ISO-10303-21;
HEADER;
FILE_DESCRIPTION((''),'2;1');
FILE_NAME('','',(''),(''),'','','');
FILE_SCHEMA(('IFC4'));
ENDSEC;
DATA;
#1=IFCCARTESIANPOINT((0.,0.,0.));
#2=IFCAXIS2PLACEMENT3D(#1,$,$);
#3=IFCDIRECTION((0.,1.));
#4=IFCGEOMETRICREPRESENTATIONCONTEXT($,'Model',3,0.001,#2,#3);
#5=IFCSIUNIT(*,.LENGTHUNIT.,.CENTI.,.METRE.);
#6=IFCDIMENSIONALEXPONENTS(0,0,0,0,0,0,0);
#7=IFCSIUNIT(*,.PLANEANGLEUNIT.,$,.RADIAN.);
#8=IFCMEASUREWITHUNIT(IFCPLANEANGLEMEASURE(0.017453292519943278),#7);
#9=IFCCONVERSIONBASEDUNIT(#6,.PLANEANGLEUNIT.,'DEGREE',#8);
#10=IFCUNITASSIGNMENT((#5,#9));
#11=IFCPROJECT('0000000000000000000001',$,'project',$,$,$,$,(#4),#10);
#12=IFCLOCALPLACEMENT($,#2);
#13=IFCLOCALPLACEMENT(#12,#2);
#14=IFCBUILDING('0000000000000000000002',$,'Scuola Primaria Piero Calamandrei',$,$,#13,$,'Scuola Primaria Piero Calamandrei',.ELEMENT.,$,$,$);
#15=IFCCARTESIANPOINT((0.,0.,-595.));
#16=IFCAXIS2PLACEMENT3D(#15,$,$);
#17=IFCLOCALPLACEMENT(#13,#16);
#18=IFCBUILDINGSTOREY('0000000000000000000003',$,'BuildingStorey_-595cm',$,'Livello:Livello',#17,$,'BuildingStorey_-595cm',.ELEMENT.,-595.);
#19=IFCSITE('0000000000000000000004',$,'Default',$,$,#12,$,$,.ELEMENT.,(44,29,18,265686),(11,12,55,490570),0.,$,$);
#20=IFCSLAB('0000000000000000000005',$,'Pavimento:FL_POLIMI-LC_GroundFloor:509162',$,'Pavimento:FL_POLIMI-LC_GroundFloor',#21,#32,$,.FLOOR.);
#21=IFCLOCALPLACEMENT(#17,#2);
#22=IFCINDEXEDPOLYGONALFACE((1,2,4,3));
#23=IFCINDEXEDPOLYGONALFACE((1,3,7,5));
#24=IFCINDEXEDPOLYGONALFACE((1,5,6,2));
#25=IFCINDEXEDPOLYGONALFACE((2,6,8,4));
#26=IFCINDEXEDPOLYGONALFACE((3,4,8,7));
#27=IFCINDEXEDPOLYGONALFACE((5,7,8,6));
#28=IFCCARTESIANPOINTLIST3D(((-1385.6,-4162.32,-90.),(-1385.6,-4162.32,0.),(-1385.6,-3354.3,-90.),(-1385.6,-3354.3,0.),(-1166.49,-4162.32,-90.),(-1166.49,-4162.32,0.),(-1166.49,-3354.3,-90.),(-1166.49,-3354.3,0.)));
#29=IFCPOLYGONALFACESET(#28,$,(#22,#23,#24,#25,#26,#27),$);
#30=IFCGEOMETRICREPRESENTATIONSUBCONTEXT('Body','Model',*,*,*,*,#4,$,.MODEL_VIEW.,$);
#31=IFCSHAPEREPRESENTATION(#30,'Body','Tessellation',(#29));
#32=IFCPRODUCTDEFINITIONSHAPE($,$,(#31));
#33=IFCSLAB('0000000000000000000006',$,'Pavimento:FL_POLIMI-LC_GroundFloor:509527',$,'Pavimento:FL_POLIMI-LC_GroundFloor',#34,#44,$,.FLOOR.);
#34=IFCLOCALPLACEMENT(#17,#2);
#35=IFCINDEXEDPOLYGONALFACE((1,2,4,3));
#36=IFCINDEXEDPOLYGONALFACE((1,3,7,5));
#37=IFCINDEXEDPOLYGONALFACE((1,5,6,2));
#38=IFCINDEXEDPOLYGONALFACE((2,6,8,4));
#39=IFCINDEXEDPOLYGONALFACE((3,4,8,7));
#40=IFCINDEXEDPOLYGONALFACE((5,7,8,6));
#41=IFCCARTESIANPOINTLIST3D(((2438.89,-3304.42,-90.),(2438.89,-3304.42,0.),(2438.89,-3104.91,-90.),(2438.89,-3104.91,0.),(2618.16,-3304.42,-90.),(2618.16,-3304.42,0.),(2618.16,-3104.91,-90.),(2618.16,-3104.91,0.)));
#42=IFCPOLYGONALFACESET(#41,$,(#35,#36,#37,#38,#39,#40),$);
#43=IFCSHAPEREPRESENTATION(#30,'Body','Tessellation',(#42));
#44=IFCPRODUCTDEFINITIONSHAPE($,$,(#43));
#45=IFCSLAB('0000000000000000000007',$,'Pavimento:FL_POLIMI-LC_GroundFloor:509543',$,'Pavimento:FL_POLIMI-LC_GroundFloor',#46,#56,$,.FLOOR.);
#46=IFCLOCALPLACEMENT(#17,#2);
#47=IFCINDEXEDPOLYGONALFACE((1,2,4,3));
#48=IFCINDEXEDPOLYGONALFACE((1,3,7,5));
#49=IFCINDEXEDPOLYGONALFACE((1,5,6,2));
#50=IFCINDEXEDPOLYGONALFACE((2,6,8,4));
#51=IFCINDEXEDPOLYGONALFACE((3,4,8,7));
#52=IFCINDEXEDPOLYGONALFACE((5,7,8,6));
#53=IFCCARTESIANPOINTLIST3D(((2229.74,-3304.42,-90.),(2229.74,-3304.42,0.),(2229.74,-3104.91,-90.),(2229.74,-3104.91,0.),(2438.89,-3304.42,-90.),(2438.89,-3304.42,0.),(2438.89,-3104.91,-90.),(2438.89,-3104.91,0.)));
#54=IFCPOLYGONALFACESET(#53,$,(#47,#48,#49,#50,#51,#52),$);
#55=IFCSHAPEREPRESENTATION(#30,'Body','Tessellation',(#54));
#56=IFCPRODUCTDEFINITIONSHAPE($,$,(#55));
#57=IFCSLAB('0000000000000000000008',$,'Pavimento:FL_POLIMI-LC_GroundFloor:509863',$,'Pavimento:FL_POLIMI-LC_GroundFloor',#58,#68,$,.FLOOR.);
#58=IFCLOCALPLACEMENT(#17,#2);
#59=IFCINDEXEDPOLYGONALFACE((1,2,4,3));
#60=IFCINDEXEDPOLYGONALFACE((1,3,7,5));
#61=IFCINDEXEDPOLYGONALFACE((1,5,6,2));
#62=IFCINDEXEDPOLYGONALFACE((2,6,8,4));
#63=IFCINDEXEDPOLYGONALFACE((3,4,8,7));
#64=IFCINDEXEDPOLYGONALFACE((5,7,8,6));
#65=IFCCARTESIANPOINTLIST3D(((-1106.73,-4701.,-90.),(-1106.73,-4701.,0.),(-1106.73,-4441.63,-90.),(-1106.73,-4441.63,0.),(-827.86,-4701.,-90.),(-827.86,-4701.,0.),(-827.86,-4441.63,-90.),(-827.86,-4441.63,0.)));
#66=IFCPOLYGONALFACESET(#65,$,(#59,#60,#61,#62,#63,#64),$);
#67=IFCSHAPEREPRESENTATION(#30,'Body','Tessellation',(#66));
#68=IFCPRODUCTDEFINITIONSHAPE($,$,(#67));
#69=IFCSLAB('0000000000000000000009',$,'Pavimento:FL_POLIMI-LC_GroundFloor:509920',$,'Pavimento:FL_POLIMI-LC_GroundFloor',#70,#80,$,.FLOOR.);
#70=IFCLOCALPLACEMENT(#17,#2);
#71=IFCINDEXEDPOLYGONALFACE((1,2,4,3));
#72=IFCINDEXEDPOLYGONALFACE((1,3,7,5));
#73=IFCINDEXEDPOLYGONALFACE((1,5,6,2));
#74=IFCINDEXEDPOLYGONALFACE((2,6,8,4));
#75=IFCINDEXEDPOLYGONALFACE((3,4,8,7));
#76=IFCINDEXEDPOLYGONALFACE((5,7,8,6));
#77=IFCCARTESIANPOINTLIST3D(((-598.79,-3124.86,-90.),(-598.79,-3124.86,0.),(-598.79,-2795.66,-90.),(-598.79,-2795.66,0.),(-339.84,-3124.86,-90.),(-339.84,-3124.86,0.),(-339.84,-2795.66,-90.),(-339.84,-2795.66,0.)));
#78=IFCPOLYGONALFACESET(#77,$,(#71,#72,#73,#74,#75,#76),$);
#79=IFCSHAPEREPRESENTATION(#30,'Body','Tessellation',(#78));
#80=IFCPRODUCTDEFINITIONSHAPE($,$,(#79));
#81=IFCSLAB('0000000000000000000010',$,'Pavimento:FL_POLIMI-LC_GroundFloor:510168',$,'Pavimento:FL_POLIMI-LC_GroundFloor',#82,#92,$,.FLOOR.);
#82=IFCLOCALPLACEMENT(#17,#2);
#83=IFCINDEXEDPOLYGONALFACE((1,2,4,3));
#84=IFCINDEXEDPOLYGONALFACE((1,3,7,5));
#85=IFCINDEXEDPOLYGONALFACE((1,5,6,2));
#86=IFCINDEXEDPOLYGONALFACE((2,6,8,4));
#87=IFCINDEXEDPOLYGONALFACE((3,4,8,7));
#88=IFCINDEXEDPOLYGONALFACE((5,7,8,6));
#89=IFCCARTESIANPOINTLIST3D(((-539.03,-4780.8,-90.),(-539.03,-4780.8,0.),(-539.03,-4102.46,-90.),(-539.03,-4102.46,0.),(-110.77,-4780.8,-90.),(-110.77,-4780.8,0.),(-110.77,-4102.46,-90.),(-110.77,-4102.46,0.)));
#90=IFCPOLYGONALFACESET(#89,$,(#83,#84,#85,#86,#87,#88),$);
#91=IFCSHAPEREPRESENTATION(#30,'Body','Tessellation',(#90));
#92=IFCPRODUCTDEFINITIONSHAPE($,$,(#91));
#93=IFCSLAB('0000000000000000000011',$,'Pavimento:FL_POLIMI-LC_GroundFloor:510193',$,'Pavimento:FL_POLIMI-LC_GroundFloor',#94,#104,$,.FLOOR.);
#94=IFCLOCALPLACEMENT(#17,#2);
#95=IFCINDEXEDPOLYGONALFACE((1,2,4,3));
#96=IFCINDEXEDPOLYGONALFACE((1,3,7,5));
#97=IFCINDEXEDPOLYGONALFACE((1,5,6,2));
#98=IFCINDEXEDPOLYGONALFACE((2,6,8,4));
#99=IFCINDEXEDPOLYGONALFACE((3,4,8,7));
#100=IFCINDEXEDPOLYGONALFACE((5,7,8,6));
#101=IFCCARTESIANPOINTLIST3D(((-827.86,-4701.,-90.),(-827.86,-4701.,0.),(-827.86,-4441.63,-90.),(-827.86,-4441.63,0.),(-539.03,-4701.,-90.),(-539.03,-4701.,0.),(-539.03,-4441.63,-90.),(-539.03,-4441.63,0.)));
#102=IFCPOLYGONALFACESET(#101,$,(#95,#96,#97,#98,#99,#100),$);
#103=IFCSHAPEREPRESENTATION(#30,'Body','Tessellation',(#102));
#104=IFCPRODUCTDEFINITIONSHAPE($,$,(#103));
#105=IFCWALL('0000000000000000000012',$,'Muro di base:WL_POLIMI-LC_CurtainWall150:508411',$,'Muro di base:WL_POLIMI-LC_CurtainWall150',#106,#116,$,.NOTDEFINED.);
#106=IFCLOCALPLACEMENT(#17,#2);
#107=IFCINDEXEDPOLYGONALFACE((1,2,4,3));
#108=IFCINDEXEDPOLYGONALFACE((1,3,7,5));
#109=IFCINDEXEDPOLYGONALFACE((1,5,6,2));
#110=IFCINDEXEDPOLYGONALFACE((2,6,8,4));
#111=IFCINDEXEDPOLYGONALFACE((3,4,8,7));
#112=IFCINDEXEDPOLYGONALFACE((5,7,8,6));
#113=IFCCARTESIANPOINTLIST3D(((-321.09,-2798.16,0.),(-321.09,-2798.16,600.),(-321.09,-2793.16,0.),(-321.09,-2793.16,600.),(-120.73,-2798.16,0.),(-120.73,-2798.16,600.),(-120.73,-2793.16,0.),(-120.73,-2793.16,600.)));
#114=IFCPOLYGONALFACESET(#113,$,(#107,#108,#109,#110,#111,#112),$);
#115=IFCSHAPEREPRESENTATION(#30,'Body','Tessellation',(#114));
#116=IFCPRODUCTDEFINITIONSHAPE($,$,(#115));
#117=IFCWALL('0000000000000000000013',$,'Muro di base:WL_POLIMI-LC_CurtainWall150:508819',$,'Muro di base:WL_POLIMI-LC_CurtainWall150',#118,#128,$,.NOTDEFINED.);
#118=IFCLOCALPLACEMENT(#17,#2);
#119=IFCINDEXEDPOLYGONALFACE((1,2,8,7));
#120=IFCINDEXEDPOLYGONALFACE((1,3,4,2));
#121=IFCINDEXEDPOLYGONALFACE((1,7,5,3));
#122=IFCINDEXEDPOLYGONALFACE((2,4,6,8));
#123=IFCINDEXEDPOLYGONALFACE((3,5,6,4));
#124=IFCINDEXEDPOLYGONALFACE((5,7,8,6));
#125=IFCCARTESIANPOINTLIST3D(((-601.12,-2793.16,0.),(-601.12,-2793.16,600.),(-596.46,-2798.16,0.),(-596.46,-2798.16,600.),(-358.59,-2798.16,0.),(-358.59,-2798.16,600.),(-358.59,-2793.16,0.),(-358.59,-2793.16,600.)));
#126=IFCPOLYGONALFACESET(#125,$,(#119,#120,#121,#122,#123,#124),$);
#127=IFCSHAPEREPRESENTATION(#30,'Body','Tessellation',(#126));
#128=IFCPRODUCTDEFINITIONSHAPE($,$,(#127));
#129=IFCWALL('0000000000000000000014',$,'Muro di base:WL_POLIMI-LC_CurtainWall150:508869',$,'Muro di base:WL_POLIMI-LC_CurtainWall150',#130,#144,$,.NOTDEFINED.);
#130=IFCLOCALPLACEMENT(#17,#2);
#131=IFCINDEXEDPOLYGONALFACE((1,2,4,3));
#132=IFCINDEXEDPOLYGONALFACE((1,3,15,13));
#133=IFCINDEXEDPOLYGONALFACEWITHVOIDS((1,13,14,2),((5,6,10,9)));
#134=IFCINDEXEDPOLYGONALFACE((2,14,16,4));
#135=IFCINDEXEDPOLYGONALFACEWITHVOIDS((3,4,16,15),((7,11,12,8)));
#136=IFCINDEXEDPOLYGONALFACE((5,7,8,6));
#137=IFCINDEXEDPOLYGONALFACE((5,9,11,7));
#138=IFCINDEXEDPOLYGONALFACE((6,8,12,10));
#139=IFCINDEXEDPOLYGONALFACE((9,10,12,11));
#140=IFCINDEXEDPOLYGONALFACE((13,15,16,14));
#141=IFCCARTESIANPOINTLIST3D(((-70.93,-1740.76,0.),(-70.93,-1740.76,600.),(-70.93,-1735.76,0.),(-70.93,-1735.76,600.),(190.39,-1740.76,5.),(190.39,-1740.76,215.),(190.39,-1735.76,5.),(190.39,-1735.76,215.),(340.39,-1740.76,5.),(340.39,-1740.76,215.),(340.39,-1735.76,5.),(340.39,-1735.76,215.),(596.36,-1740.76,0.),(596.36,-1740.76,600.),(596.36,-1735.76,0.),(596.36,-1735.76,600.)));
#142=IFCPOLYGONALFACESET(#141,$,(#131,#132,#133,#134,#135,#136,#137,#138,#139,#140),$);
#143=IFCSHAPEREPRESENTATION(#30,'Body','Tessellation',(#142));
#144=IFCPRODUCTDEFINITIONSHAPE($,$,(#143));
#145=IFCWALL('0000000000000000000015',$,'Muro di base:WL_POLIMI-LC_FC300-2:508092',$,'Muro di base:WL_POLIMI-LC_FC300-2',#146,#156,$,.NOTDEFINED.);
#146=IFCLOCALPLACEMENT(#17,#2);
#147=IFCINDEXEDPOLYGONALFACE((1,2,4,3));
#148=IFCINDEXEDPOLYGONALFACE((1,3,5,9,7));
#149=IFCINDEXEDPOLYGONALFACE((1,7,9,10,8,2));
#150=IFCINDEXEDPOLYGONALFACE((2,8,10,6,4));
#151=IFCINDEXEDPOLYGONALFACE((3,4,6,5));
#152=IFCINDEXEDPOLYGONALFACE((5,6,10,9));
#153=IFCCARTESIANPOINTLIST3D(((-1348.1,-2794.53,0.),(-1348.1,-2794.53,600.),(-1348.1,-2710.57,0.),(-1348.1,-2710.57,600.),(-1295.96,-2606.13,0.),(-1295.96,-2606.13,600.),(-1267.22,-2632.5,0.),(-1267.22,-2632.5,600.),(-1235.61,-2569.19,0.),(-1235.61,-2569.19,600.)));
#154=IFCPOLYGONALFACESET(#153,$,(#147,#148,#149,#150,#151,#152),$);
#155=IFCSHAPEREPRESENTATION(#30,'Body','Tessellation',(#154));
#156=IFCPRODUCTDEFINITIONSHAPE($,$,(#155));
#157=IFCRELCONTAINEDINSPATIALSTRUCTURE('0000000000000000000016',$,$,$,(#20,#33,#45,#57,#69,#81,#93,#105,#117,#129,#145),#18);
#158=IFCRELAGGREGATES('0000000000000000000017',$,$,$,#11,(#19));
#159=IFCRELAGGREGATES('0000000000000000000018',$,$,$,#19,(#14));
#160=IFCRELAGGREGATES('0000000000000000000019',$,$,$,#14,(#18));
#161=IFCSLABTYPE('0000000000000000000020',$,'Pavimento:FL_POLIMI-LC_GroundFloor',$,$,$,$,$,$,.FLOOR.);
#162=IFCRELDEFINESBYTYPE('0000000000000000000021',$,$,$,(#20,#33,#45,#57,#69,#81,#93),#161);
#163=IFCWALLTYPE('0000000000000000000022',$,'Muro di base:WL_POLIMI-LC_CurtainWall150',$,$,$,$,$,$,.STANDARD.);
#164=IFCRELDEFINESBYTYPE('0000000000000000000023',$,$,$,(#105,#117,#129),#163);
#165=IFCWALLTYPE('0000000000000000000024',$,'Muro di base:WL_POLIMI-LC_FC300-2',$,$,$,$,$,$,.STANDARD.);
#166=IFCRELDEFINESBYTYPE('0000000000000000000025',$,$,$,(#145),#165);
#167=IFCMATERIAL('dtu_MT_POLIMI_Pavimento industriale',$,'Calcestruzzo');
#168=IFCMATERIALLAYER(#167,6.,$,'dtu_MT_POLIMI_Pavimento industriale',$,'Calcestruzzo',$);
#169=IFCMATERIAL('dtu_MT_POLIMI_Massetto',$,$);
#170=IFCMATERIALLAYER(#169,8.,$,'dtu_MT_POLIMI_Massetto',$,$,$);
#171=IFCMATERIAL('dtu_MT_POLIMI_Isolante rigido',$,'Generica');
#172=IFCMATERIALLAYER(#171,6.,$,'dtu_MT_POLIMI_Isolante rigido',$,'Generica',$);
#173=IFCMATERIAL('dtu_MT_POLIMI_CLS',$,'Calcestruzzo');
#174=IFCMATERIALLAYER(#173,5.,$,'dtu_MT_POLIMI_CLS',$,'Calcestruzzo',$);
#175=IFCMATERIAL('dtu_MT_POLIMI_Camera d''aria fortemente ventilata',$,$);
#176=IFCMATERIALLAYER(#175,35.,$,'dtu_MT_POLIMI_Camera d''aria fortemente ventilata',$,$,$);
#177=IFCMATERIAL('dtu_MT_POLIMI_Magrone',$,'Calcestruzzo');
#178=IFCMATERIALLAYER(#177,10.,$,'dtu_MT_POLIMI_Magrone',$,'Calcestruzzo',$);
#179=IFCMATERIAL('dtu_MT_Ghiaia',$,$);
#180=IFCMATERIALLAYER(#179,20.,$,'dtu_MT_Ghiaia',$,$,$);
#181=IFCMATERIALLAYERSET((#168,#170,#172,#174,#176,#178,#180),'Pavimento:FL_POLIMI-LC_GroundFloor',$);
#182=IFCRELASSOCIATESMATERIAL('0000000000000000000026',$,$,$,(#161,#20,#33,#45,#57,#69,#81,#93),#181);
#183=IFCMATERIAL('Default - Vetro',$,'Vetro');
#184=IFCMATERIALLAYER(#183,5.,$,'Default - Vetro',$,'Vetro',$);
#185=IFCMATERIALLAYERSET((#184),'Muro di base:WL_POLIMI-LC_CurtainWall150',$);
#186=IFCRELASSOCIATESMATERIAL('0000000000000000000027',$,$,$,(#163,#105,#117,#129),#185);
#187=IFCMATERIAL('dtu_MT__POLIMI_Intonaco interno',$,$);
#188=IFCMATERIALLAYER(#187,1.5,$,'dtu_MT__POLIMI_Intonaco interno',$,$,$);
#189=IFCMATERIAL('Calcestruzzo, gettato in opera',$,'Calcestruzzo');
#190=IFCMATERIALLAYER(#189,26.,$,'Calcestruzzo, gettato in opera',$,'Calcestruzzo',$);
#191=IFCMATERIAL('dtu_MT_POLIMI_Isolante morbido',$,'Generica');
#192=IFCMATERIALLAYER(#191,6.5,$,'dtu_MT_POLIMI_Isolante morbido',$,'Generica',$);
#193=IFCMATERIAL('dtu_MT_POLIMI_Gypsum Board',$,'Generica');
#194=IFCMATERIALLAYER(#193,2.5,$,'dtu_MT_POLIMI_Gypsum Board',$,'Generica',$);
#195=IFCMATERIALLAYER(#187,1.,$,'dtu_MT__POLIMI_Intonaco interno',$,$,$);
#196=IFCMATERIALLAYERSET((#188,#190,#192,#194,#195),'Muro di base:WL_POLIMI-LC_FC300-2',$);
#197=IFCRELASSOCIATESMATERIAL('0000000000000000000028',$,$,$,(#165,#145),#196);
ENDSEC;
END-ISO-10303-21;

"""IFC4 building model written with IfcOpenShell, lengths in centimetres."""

from ifc_helpers import new_model, entity, si_unit, converted_unit, direction, frame, frame_2d, origin, place, context, subcontext, project, spatial, polyline, rectangle, outline, extrude, material, layer, layer_set, layer_usage, type_object, element, save


model = new_model("IFC4")

# Units and contexts
model_context = context("Model", 3, precision=0.001, world=origin(), true_north=direction((0.0, 1.0)))
body_context = subcontext(model_context, "Body", "Model", "MODEL_VIEW")
ifc_project = project(units=[si_unit("LENGTHUNIT", "METRE", prefix="CENTI"), converted_unit("PLANEANGLEUNIT", "DEGREE", entity("IfcPlaneAngleMeasure", 0.017453292519943278), si_unit("PLANEANGLEUNIT", "RADIAN"), dimensions=[0, 0, 0, 0, 0, 0, 0])], contexts=[model_context])

# Site, building, storey
site_placement = place(None, origin())
site = spatial("IfcSite", under=ifc_project, at=site_placement, Name="Default", CompositionType="ELEMENT", RefLatitude=(44, 29, 18, 265686), RefLongitude=(11, 12, 55, 490570), RefElevation=0.0)
building_placement = place(site_placement, origin())
building = spatial("IfcBuilding", under=site, at=building_placement, Name="Scuola Primaria Piero Calamandrei", LongName="Scuola Primaria Piero Calamandrei", CompositionType="ELEMENT")
storey_placement = place(building_placement, frame((0.0, 0.0, -595.0)))
storey = spatial("IfcBuildingStorey", under=building, at=storey_placement, Name="BuildingStorey_-595cm", ObjectType="Livello:Livello", LongName="BuildingStorey_-595cm", CompositionType="ELEMENT", Elevation=-595.0)

# Slabs
ifc_material_1 = material(Name="dtu_MT_POLIMI_Pavimento industriale", Category="Calcestruzzo")
ifc_layer_1 = layer(ifc_material_1, 6.0, Name="dtu_MT_POLIMI_Pavimento industriale", Category="Calcestruzzo")
ifc_material_2 = material(Name="dtu_MT_POLIMI_Massetto")
ifc_layer_2 = layer(ifc_material_2, 8.0, Name="dtu_MT_POLIMI_Massetto")
ifc_material_3 = material(Name="dtu_MT_POLIMI_Isolante rigido", Category="Generica")
ifc_layer_3 = layer(ifc_material_3, 6.0, Name="dtu_MT_POLIMI_Isolante rigido", Category="Generica")
ifc_material_4 = material(Name="dtu_MT_POLIMI_CLS", Category="Calcestruzzo")
ifc_layer_4 = layer(ifc_material_4, 5.0, Name="dtu_MT_POLIMI_CLS", Category="Calcestruzzo")
ifc_material_5 = material(Name="dtu_MT_POLIMI_Camera d'aria fortemente ventilata")
ifc_layer_5 = layer(ifc_material_5, 35.0, Name="dtu_MT_POLIMI_Camera d'aria fortemente ventilata")
ifc_material_6 = material(Name="dtu_MT_POLIMI_Magrone", Category="Calcestruzzo")
ifc_layer_6 = layer(ifc_material_6, 10.0, Name="dtu_MT_POLIMI_Magrone", Category="Calcestruzzo")
ifc_material_7 = material(Name="dtu_MT_Ghiaia")
ifc_layer_7 = layer(ifc_material_7, 20.0, Name="dtu_MT_Ghiaia")
ifc_layer_set_1 = layer_set([ifc_layer_1, ifc_layer_2, ifc_layer_3, ifc_layer_4, ifc_layer_5, ifc_layer_6, ifc_layer_7], Name="Pavimento:FL_POLIMI-LC_GroundFloor")
slab_type = type_object("IfcSlabType", Name="Pavimento:FL_POLIMI-LC_GroundFloor", PredefinedType="FLOOR", material=ifc_layer_set_1)
ifc_layer_usage_1 = layer_usage(ifc_layer_set_1, "AXIS3", "POSITIVE", 0.0)
slab_1_placement = place(storey_placement, origin())
element("IfcSlab", 1, at=slab_1_placement, inside=storey, type_object=slab_type, material=ifc_layer_usage_1, Name="Pavimento:FL_POLIMI-LC_GroundFloor:509162", ObjectType="Pavimento:FL_POLIMI-LC_GroundFloor", PredefinedType="FLOOR", context=body_context, shape_type="SweptSolid", body=[
    extrude(rectangle(XDim=808.02, YDim=219.11, at=frame_2d((0.0, 0.0), x_axis=(1.0, 0.0))), frame((-1276.05, -3758.31, 0.0), z_axis=(0.0, 0.0, -1.0), x_axis=(0.0, 1.0, 0.0)), (0.0, 0.0, 1.0), 90.0),
])
ifc_layer_usage_2 = layer_usage(ifc_layer_set_1, "AXIS3", "POSITIVE", 0.0)
slab_2_placement = place(storey_placement, origin())
element("IfcSlab", 2, at=slab_2_placement, inside=storey, type_object=slab_type, material=ifc_layer_usage_2, Name="Pavimento:FL_POLIMI-LC_GroundFloor:509527", ObjectType="Pavimento:FL_POLIMI-LC_GroundFloor", PredefinedType="FLOOR", context=body_context, shape_type="SweptSolid", body=[
    extrude(rectangle(XDim=199.51, YDim=179.27, at=frame_2d((0.0, 0.0), x_axis=(1.0, 0.0))), frame((2528.53, -3204.66, 0.0), z_axis=(0.0, 0.0, -1.0), x_axis=(0.0, 1.0, 0.0)), (0.0, 0.0, 1.0), 90.0),
])
ifc_layer_usage_3 = layer_usage(ifc_layer_set_1, "AXIS3", "POSITIVE", 0.0)
slab_3_placement = place(storey_placement, origin())
element("IfcSlab", 3, at=slab_3_placement, inside=storey, type_object=slab_type, material=ifc_layer_usage_3, Name="Pavimento:FL_POLIMI-LC_GroundFloor:509543", ObjectType="Pavimento:FL_POLIMI-LC_GroundFloor", PredefinedType="FLOOR", context=body_context, shape_type="SweptSolid", body=[
    extrude(rectangle(XDim=199.51, YDim=209.15, at=frame_2d((0.0, 0.0), x_axis=(1.0, 0.0))), frame((2334.32, -3204.66, 0.0), z_axis=(0.0, 0.0, -1.0), x_axis=(0.0, 1.0, 0.0)), (0.0, 0.0, 1.0), 90.0),
])
ifc_layer_usage_4 = layer_usage(ifc_layer_set_1, "AXIS3", "POSITIVE", 0.0)
slab_4_placement = place(storey_placement, origin())
element("IfcSlab", 4, at=slab_4_placement, inside=storey, type_object=slab_type, material=ifc_layer_usage_4, Name="Pavimento:FL_POLIMI-LC_GroundFloor:509863", ObjectType="Pavimento:FL_POLIMI-LC_GroundFloor", PredefinedType="FLOOR", context=body_context, shape_type="SweptSolid", body=[
    extrude(rectangle(XDim=259.36, YDim=278.87, at=frame_2d((0.0, 0.0), x_axis=(1.0, 0.0))), frame((-967.3, -4571.31, 0.0), z_axis=(0.0, 0.0, -1.0), x_axis=(0.0, 1.0, 0.0)), (0.0, 0.0, 1.0), 90.0),
])
ifc_layer_usage_5 = layer_usage(ifc_layer_set_1, "AXIS3", "POSITIVE", 0.0)
slab_5_placement = place(storey_placement, origin())
element("IfcSlab", 5, at=slab_5_placement, inside=storey, type_object=slab_type, material=ifc_layer_usage_5, Name="Pavimento:FL_POLIMI-LC_GroundFloor:509920", ObjectType="Pavimento:FL_POLIMI-LC_GroundFloor", PredefinedType="FLOOR", context=body_context, shape_type="SweptSolid", body=[
    extrude(rectangle(XDim=329.19, YDim=258.95, at=frame_2d((0.0, 0.0), x_axis=(1.0, 0.0))), frame((-469.32, -2960.26, 0.0), z_axis=(0.0, 0.0, -1.0), x_axis=(0.0, 1.0, 0.0)), (0.0, 0.0, 1.0), 90.0),
])
ifc_layer_usage_6 = layer_usage(ifc_layer_set_1, "AXIS3", "POSITIVE", 0.0)
slab_6_placement = place(storey_placement, origin())
element("IfcSlab", 6, at=slab_6_placement, inside=storey, type_object=slab_type, material=ifc_layer_usage_6, Name="Pavimento:FL_POLIMI-LC_GroundFloor:510168", ObjectType="Pavimento:FL_POLIMI-LC_GroundFloor", PredefinedType="FLOOR", context=body_context, shape_type="SweptSolid", body=[
    extrude(rectangle(XDim=428.26, YDim=678.34, at=frame_2d((0.0, 0.0), x_axis=(1.0, 0.0))), frame((-324.9, -4441.63, 0.0), z_axis=(0.0, 0.0, -1.0), x_axis=(1.0, 0.0, 0.0)), (0.0, 0.0, 1.0), 90.0),
])
ifc_layer_usage_7 = layer_usage(ifc_layer_set_1, "AXIS3", "POSITIVE", 0.0)
slab_7_placement = place(storey_placement, origin())
element("IfcSlab", 7, at=slab_7_placement, inside=storey, type_object=slab_type, material=ifc_layer_usage_7, Name="Pavimento:FL_POLIMI-LC_GroundFloor:510193", ObjectType="Pavimento:FL_POLIMI-LC_GroundFloor", PredefinedType="FLOOR", context=body_context, shape_type="SweptSolid", body=[
    extrude(rectangle(XDim=259.36, YDim=288.83, at=frame_2d((0.0, 0.0), x_axis=(1.0, 0.0))), frame((-683.45, -4571.31, 0.0), z_axis=(0.0, 0.0, -1.0), x_axis=(0.0, 1.0, 0.0)), (0.0, 0.0, 1.0), 90.0),
])

# Walls
ifc_material_8 = material(Name="Default - Vetro", Category="Vetro")
ifc_layer_8 = layer(ifc_material_8, 5.0, Name="Default - Vetro", Category="Vetro")
ifc_layer_set_2 = layer_set([ifc_layer_8], Name="Muro di base:WL_POLIMI-LC_CurtainWall150")
ifc_layer_usage_8 = layer_usage(ifc_layer_set_2, "AXIS2", "NEGATIVE", 2.5)
wall_type_1 = type_object("IfcWallType", Name="Muro di base:WL_POLIMI-LC_CurtainWall150", PredefinedType="STANDARD", material=ifc_layer_set_2)
wall_1_placement = place(storey_placement, frame((-321.09, -2795.66, 0.0)))
element("IfcWall", 8, at=wall_1_placement, inside=storey, type_object=wall_type_1, material=ifc_layer_usage_8, Name="Muro di base:WL_POLIMI-LC_CurtainWall150:508411", ObjectType="Muro di base:WL_POLIMI-LC_CurtainWall150", PredefinedType="NOTDEFINED", context=body_context, shape_type="SweptSolid", body=[
    extrude(rectangle(XDim=200.36, YDim=5.0, at=frame_2d((100.18, 0.0), x_axis=(-1.0, 0.0))), origin(), (0.0, 0.0, 1.0), 600.0),
])
ifc_layer_usage_9 = layer_usage(ifc_layer_set_2, "AXIS2", "NEGATIVE", 2.5)
wall_2_placement = place(storey_placement, frame((-601.12, -2795.66, 0.0)))
element("IfcWall", 9, at=wall_2_placement, inside=storey, type_object=wall_type_1, material=ifc_layer_usage_9, Name="Muro di base:WL_POLIMI-LC_CurtainWall150:508819", ObjectType="Muro di base:WL_POLIMI-LC_CurtainWall150", PredefinedType="NOTDEFINED", context=body_context, shape_type="SweptSolid", body=[
    extrude(outline(polyline([(242.53, -2.5), (242.53, 2.5), (0.0, 2.5), (4.66, -2.5), (242.53, -2.5)])), origin(), (0.0, 0.0, 1.0), 600.0),
])

# Wall, opening
ifc_layer_usage_10 = layer_usage(ifc_layer_set_2, "AXIS2", "NEGATIVE", 2.5)
wall_3_placement = place(storey_placement, frame((-70.93, -1738.26, 0.0)))
wall_3 = element("IfcWall", 10, at=wall_3_placement, inside=storey, type_object=wall_type_1, material=ifc_layer_usage_10, Name="Muro di base:WL_POLIMI-LC_CurtainWall150:508869", ObjectType="Muro di base:WL_POLIMI-LC_CurtainWall150", PredefinedType="NOTDEFINED", context=body_context, shape_type="SweptSolid", body=[
    extrude(rectangle(XDim=667.29, YDim=5.0, at=frame_2d((333.65, 0.0), x_axis=(-1.0, 0.0))), origin(), (0.0, 0.0, 1.0), 600.0),
])
opening_1_placement = place(wall_3_placement, frame((411.32, 2.5, 5.0)))
element("IfcOpeningElement", 11, at=opening_1_placement, cuts=wall_3, PredefinedType="OPENING", context=body_context, shape_type="SweptSolid", body=[
    extrude(rectangle(XDim=210.0, YDim=150.0, at=frame_2d((105.0, 75.0), x_axis=(-1.0, 0.0))), frame((0.0, 0.0, 0.0), z_axis=(0.0, -1.0, 0.0), x_axis=(0.0, 0.0, 1.0)), (0.0, 0.0, 1.0), 5.0),
])

# Wall
ifc_material_9 = material(Name="dtu_MT__POLIMI_Intonaco interno")
ifc_layer_9 = layer(ifc_material_9, 1.5, Name="dtu_MT__POLIMI_Intonaco interno")
ifc_material_10 = material(Name="Calcestruzzo, gettato in opera", Category="Calcestruzzo")
ifc_layer_10 = layer(ifc_material_10, 26.0, Name="Calcestruzzo, gettato in opera", Category="Calcestruzzo")
ifc_material_11 = material(Name="dtu_MT_POLIMI_Isolante morbido", Category="Generica")
ifc_layer_11 = layer(ifc_material_11, 6.5, Name="dtu_MT_POLIMI_Isolante morbido", Category="Generica")
ifc_material_12 = material(Name="dtu_MT_POLIMI_Gypsum Board", Category="Generica")
ifc_layer_12 = layer(ifc_material_12, 2.5, Name="dtu_MT_POLIMI_Gypsum Board", Category="Generica")
ifc_layer_13 = layer(ifc_material_9, 1.0, Name="dtu_MT__POLIMI_Intonaco interno")
ifc_layer_set_3 = layer_set([ifc_layer_9, ifc_layer_10, ifc_layer_11, ifc_layer_12, ifc_layer_13], Name="Muro di base:WL_POLIMI-LC_FC300-2")
ifc_layer_usage_11 = layer_usage(ifc_layer_set_3, "AXIS2", "NEGATIVE", 18.75)
wall_type_2 = type_object("IfcWallType", Name="Muro di base:WL_POLIMI-LC_FC300-2", PredefinedType="STANDARD", material=ifc_layer_set_3)
wall_4_placement = place(storey_placement, frame((-1364.88, -2786.15, 0.0), z_axis=(0.0, 0.0, 1.0), x_axis=(0.446642, 0.894713, 0.0)))
element("IfcWall", 12, at=wall_4_placement, inside=storey, type_object=wall_type_2, material=ifc_layer_usage_11, Name="Muro di base:WL_POLIMI-LC_FC300-2:508092", ObjectType="Muro di base:WL_POLIMI-LC_FC300-2", PredefinedType="NOTDEFINED", context=body_context, shape_type="SweptSolid", body=[
    extrude(outline(polyline([(251.86, -18.75), (191.85, 18.75), (75.12, 18.75), (0.0, -18.75), (181.1, -18.75), (251.86, -18.75)])), origin(), (0.0, 0.0, 1.0), 600.0),
])

save(model, "model.ifc")
